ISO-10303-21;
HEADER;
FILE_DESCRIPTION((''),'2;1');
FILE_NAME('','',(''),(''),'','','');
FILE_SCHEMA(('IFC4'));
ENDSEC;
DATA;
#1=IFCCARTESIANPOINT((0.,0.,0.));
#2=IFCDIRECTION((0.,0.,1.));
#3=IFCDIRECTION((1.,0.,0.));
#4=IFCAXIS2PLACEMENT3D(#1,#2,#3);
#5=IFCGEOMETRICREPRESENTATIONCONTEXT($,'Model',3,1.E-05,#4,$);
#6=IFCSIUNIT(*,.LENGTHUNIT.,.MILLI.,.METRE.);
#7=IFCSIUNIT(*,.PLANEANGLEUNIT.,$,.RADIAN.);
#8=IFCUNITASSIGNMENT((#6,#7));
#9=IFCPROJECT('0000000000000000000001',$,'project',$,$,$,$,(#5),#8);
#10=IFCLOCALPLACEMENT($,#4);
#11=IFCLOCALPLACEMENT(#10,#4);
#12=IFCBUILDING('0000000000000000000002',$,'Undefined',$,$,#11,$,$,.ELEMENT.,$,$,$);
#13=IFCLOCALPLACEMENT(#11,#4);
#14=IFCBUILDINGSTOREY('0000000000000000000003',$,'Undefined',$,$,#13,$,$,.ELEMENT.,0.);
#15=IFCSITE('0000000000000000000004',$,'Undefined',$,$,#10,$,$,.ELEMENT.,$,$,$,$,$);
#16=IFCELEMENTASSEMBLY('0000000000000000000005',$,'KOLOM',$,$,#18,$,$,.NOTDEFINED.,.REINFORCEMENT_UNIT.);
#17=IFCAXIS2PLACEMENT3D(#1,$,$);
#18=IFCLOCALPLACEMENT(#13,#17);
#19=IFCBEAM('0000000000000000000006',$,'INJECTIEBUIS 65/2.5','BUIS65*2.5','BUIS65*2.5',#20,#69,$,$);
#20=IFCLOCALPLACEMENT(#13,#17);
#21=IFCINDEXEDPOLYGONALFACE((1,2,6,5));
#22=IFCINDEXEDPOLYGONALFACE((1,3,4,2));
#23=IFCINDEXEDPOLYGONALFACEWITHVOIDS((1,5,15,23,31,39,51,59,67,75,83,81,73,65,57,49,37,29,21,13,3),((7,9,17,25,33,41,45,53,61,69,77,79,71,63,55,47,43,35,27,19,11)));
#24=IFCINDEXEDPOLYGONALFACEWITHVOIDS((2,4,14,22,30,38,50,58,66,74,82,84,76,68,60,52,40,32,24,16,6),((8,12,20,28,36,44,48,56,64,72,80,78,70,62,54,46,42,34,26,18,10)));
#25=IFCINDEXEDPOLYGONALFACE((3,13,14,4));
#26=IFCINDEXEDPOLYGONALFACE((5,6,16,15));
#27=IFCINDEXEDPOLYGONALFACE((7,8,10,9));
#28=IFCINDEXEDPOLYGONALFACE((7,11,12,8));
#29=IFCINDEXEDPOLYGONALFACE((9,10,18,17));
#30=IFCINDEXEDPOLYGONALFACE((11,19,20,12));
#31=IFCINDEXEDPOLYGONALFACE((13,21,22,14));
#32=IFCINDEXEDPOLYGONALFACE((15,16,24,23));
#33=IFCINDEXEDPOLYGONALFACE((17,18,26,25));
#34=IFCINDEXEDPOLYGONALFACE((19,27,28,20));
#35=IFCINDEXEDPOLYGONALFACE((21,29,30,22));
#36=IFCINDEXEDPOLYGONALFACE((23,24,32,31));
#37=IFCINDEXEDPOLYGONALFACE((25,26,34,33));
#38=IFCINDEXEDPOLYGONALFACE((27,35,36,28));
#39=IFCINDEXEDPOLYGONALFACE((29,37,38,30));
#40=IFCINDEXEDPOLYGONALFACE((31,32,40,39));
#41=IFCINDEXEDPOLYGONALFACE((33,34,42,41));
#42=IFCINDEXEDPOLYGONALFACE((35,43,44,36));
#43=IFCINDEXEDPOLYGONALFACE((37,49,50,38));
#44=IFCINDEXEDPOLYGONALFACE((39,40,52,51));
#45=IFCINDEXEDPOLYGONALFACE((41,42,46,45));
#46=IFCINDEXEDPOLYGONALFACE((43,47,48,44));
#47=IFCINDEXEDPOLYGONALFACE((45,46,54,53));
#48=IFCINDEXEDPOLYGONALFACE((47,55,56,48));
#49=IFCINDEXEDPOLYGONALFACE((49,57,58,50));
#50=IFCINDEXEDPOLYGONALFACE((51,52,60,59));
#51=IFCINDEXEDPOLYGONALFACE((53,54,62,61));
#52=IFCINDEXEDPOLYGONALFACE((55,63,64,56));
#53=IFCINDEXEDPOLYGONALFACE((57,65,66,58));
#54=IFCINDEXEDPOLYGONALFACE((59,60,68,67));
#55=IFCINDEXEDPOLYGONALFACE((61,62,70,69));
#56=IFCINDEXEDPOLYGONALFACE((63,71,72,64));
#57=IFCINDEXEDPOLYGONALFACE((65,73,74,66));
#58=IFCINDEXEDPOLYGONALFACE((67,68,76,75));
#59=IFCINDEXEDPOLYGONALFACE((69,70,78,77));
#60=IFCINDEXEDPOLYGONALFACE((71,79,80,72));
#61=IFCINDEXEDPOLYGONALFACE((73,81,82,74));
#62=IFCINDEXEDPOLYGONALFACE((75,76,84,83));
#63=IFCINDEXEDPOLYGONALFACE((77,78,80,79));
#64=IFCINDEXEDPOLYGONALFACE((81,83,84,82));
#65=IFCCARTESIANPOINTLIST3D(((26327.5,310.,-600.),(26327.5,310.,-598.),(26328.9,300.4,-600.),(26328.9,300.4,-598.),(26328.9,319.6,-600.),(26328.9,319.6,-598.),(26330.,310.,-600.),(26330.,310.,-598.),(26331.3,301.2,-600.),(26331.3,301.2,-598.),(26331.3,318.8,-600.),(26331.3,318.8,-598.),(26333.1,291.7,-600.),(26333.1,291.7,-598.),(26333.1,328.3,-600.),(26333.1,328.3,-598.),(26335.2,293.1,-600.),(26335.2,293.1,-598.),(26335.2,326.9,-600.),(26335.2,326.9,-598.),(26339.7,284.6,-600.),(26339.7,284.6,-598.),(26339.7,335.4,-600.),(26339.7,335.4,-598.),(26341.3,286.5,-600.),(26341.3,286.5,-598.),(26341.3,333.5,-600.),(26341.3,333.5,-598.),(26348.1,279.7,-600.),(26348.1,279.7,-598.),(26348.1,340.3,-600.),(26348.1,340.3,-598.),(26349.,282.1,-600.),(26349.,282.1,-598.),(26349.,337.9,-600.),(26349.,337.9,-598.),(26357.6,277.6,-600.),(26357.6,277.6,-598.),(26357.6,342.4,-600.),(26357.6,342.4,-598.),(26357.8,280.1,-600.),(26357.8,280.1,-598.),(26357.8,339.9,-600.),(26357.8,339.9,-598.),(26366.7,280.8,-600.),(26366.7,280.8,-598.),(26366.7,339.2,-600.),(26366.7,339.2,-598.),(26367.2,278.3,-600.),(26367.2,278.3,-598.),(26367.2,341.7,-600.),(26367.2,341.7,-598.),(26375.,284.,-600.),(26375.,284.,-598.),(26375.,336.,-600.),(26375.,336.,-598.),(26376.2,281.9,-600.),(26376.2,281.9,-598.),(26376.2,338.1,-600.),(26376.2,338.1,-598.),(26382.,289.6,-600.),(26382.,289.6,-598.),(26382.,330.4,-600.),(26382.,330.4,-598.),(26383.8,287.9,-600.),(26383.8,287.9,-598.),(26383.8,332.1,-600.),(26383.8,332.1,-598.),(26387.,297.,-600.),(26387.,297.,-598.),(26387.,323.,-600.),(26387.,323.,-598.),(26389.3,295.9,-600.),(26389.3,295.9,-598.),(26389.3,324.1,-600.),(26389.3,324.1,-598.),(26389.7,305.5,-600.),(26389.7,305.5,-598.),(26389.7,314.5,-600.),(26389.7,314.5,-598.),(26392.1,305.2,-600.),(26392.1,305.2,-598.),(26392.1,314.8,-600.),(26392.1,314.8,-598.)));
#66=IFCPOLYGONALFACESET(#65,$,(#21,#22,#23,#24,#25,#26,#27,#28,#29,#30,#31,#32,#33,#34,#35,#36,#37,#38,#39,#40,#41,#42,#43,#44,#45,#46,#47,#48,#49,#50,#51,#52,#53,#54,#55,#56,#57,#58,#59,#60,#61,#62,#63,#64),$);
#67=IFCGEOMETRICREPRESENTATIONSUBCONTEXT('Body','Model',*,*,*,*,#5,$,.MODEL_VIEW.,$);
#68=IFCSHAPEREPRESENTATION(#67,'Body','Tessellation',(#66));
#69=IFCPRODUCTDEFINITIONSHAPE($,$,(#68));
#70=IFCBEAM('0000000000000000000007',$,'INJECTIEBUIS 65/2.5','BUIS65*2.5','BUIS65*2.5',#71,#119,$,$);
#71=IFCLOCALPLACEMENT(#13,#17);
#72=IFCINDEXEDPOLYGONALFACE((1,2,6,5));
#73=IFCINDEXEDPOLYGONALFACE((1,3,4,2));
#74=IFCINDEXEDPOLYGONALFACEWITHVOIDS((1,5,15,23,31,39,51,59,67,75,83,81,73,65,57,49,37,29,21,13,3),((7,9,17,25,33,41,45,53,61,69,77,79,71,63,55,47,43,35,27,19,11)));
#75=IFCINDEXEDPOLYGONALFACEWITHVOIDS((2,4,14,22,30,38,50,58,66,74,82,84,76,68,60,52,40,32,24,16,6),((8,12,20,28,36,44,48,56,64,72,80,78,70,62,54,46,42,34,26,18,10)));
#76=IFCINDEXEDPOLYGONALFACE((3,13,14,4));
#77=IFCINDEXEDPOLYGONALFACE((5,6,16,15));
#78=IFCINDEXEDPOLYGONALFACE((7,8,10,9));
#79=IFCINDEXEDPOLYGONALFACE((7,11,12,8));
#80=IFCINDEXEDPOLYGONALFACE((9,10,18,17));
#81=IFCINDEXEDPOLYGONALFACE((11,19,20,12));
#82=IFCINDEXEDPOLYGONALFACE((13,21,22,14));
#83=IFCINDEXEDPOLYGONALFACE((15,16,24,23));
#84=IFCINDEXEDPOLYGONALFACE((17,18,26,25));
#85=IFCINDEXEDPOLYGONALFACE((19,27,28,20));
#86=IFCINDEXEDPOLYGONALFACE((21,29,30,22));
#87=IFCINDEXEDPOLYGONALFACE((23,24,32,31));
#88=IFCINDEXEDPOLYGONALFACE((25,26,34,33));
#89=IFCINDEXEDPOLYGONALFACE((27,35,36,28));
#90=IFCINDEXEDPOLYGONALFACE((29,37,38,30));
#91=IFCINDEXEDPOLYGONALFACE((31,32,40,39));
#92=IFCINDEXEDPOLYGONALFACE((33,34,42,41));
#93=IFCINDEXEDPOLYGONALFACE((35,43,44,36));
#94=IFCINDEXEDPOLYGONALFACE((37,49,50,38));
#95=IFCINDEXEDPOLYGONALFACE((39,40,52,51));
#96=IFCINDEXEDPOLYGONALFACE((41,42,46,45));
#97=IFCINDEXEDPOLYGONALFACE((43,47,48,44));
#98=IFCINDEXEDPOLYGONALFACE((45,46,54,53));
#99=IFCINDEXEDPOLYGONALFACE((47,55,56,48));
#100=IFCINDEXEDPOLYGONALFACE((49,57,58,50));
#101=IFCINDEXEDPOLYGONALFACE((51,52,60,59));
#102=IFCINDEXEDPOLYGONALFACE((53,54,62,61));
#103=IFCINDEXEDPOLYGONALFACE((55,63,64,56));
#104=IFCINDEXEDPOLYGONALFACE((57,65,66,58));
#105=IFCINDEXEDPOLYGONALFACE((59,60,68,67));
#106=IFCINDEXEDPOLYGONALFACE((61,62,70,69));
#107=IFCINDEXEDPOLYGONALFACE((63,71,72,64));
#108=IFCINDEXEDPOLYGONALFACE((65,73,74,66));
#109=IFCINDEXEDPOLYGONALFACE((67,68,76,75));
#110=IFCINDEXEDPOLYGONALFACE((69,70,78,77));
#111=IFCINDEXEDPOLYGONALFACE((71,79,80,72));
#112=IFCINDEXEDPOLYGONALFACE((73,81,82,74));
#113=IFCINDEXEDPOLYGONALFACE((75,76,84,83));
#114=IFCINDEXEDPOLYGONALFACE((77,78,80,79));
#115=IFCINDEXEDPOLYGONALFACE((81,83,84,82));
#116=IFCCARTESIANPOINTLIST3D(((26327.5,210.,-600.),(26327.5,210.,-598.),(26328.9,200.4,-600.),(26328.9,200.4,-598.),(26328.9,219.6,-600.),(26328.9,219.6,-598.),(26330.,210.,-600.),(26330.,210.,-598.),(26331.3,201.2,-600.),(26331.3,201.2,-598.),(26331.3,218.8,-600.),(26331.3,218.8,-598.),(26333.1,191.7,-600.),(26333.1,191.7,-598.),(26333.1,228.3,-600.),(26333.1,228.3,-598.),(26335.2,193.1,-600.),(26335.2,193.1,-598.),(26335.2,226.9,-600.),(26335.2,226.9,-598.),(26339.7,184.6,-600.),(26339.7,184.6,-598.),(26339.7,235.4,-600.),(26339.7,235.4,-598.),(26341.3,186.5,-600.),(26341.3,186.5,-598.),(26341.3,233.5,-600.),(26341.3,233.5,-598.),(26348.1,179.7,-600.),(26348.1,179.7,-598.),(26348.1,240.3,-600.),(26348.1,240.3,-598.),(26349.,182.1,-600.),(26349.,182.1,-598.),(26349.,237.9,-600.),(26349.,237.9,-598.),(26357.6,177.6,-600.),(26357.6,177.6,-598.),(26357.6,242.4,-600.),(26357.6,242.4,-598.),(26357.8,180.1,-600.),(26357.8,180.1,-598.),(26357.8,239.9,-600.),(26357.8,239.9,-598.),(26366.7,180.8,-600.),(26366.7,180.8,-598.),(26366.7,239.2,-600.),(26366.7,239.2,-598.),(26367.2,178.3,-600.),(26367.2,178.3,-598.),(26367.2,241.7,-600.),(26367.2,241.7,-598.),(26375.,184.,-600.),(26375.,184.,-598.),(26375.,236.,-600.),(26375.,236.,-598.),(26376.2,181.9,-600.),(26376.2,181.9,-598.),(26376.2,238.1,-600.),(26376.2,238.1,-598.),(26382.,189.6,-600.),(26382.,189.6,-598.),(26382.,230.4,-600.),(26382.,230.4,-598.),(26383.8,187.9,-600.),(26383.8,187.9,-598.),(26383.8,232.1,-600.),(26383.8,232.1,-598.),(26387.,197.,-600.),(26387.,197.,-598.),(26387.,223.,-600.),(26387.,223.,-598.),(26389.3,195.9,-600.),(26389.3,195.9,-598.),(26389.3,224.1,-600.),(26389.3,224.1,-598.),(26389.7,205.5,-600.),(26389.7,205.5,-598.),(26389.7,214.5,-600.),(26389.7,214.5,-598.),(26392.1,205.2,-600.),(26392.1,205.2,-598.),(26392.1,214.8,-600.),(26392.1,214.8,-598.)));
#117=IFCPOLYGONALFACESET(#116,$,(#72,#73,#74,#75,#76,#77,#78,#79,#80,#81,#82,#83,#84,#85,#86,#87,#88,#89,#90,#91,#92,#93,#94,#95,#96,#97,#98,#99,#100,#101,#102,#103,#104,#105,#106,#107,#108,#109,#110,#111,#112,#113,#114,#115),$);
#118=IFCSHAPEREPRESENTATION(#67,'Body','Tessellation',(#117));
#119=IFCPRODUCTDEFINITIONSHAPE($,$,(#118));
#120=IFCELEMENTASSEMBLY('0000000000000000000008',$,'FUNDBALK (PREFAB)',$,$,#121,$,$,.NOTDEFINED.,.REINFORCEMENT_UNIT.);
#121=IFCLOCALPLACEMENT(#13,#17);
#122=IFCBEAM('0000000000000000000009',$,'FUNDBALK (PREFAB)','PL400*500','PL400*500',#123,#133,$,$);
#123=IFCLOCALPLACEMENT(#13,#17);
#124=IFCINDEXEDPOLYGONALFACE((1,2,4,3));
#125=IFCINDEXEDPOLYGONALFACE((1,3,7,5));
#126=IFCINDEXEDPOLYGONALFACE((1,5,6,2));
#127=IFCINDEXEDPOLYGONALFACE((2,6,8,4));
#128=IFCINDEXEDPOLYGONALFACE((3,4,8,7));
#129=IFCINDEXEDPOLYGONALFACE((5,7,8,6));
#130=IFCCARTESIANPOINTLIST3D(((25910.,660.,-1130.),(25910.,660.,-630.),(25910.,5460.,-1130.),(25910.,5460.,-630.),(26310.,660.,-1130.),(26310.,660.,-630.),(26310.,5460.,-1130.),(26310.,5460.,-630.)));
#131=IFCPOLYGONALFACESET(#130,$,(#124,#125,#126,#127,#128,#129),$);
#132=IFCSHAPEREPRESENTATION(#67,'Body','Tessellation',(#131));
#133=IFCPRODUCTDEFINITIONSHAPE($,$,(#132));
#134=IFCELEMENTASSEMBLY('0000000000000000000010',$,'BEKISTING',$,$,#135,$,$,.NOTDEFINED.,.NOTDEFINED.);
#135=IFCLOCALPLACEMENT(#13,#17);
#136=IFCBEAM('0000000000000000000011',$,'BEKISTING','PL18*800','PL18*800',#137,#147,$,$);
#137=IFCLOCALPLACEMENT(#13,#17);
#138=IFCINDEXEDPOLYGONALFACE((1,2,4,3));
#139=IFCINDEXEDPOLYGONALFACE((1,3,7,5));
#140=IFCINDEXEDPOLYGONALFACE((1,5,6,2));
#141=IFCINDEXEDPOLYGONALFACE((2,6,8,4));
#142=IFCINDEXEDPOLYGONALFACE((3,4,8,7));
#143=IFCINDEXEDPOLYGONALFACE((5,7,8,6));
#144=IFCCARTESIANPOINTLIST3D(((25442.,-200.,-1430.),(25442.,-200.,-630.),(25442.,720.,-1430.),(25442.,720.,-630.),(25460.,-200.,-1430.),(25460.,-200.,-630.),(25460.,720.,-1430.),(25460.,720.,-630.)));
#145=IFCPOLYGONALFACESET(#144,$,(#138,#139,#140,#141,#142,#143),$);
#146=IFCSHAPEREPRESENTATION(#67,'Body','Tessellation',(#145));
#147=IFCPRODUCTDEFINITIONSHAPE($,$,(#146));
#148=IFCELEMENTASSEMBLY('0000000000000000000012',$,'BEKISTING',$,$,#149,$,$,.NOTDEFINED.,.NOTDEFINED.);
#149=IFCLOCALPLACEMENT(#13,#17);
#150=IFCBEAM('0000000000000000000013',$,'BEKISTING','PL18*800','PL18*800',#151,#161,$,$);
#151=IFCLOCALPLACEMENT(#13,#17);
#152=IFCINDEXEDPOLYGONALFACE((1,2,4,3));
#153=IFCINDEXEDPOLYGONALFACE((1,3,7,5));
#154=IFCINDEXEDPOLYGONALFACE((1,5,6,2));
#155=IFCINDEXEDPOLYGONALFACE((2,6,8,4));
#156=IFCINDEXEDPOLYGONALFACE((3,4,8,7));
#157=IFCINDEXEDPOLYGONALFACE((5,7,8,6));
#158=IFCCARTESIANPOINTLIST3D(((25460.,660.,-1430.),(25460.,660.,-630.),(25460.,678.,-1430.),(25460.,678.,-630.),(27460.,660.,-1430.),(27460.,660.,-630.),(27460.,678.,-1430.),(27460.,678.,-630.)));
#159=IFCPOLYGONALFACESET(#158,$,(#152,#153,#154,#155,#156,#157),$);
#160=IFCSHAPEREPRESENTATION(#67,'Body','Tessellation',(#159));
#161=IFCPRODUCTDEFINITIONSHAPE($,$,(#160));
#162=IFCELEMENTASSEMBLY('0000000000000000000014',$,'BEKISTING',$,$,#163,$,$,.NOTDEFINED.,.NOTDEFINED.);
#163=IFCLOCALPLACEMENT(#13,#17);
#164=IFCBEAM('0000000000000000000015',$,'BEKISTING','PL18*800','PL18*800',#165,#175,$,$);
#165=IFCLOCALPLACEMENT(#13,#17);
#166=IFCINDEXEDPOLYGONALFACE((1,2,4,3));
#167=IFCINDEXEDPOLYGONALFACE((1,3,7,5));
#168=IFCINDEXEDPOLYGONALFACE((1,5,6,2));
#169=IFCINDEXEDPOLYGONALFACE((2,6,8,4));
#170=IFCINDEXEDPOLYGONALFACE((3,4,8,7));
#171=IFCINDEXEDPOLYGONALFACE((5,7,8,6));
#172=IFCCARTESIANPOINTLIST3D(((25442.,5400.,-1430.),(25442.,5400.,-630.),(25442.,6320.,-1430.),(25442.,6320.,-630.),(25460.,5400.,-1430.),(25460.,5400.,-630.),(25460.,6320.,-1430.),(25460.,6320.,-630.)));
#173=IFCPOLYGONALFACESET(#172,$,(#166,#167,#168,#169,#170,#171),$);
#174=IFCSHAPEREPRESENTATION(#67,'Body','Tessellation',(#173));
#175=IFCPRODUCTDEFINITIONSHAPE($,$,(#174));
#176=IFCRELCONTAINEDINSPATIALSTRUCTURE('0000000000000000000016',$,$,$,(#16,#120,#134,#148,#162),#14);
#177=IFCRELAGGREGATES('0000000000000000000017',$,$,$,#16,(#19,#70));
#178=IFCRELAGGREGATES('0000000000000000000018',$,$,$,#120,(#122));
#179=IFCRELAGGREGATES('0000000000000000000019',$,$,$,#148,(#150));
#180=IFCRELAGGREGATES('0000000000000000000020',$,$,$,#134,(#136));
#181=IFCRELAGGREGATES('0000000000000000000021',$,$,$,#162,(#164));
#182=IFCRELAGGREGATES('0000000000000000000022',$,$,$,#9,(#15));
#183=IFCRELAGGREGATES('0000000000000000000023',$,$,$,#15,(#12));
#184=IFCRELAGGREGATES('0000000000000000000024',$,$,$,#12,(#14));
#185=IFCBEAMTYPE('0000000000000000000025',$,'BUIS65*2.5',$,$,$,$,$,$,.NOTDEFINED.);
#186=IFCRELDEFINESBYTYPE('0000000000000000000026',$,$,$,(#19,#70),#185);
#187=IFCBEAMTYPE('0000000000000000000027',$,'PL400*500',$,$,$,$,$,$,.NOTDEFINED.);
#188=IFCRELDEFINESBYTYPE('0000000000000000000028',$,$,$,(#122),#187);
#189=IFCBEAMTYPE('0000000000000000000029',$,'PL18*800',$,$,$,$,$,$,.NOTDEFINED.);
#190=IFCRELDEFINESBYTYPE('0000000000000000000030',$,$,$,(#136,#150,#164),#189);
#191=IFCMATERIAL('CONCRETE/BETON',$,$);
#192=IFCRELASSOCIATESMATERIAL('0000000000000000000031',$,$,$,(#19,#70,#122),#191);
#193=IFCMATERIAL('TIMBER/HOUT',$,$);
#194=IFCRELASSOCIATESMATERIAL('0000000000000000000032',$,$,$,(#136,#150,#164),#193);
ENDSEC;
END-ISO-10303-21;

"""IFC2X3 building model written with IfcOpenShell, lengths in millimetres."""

from ifc_helpers import new_model, si_unit, frame, frame_2d, origin_with_axes, place, context, subcontext, project, spatial, rectangle, hollow_circle, extrude, material, type_object, element, aggregate, save


model = new_model("IFC2X3")

# Units and contexts
model_context = context("Model", 3, precision=1e-05, world=origin_with_axes())
body_context = subcontext(model_context, "Body", "Model", "MODEL_VIEW")
ifc_project = project(units=[si_unit("LENGTHUNIT", "METRE", prefix="MILLI"), si_unit("PLANEANGLEUNIT", "RADIAN")], contexts=[model_context])

# Site, building, storey
site_placement = place(None, origin_with_axes())
site = spatial("IfcSite", under=ifc_project, at=site_placement, Name="Undefined", CompositionType="ELEMENT")
building_placement = place(site_placement, origin_with_axes())
building = spatial("IfcBuilding", under=site, at=building_placement, Name="Undefined", CompositionType="ELEMENT")
storey_placement = place(building_placement, origin_with_axes())
storey = spatial("IfcBuildingStorey", under=building, at=storey_placement, Name="Undefined", CompositionType="ELEMENT", Elevation=0.0)

# Shared definitions
ifc_material_1 = material(Name="CONCRETE/BETON")

# Element assembly, beams
assembly_1_placement = place(storey_placement, origin_with_axes())
assembly_1 = element("IfcElementAssembly", 1, at=assembly_1_placement, inside=storey, Name="KOLOM", AssemblyPlace="NOTDEFINED", PredefinedType="REINFORCEMENT_UNIT")
beam_type_1 = type_object("IfcBeamType", Name="BUIS65*2.5", PredefinedType="NOTDEFINED")
beam_1_placement = place(assembly_1_placement, frame((26360.0, 310.0, -600.0), z_axis=(0.0, 1.0, 0.0), x_axis=(0.0, 0.0, 1.0)))
beam_1 = element("IfcBeam", 2, at=beam_1_placement, type_object=beam_type_1, material=ifc_material_1, Name="INJECTIEBUIS 65/2.5", Description="BUIS65*2.5", ObjectType="BUIS65*2.5", context=body_context, shape_type="SweptSolid", body=[
    extrude(hollow_circle(Radius=32.5, WallThickness=2.5, at=frame_2d((0.0, 0.0), x_axis=(1.0, 0.0))), frame((2.0, 0.0, 0.0), z_axis=(-1.0, 0.0, 0.0), x_axis=(0.0, -1.0, 0.0)), (0.0, 0.0, 1.0), 2.0),
])
beam_2_placement = place(assembly_1_placement, frame((26360.0, 210.0, -600.0), z_axis=(0.0, 1.0, 0.0), x_axis=(0.0, 0.0, 1.0)))
beam_2 = element("IfcBeam", 3, at=beam_2_placement, type_object=beam_type_1, material=ifc_material_1, Name="INJECTIEBUIS 65/2.5", Description="BUIS65*2.5", ObjectType="BUIS65*2.5", context=body_context, shape_type="SweptSolid", body=[
    extrude(hollow_circle(Radius=32.5, WallThickness=2.5, at=frame_2d((0.0, 0.0), x_axis=(1.0, 0.0))), frame((2.0, 0.0, 0.0), z_axis=(-1.0, 0.0, 0.0), x_axis=(0.0, -1.0, 0.0)), (0.0, 0.0, 1.0), 2.0),
])
aggregate(assembly_1, [beam_1, beam_2])

# Element assemblies, beams
assembly_2_placement = place(storey_placement, origin_with_axes())
assembly_2 = element("IfcElementAssembly", 4, at=assembly_2_placement, inside=storey, Name="FUNDBALK (PREFAB)", AssemblyPlace="NOTDEFINED", PredefinedType="REINFORCEMENT_UNIT")
beam_type_2 = type_object("IfcBeamType", Name="PL400*500", PredefinedType="NOTDEFINED")
beam_3_placement = place(assembly_2_placement, frame((26110.0, 5460.0, -880.0), z_axis=(0.0, 0.0, 1.0), x_axis=(0.0, -1.0, 0.0)))
beam_3 = element("IfcBeam", 5, at=beam_3_placement, type_object=beam_type_2, material=ifc_material_1, Name="FUNDBALK (PREFAB)", Description="PL400*500", ObjectType="PL400*500", context=body_context, shape_type="SweptSolid", body=[
    extrude(rectangle(XDim=400.0, YDim=500.0, at=frame_2d((0.0, 0.0), x_axis=(1.0, 0.0))), frame((4800.0, 0.0, 0.0), z_axis=(-1.0, 0.0, 0.0), x_axis=(0.0, -1.0, 0.0)), (0.0, 0.0, 1.0), 4800.0),
])
aggregate(assembly_2, [beam_3])
assembly_3_placement = place(storey_placement, origin_with_axes())
assembly_3 = element("IfcElementAssembly", 6, at=assembly_3_placement, inside=storey, Name="BEKISTING", AssemblyPlace="NOTDEFINED", PredefinedType="NOTDEFINED")
ifc_material_2 = material(Name="TIMBER/HOUT")
beam_type_3 = type_object("IfcBeamType", Name="PL18*800", PredefinedType="NOTDEFINED")
beam_4_placement = place(assembly_3_placement, frame((25451.0, -200.0, -1030.0), z_axis=(0.0, 0.0, -1.0), x_axis=(0.0, 1.0, 0.0)))
beam_4 = element("IfcBeam", 7, at=beam_4_placement, type_object=beam_type_3, material=ifc_material_2, Name="BEKISTING", Description="PL18*800", ObjectType="PL18*800", context=body_context, shape_type="SweptSolid", body=[
    extrude(rectangle(XDim=18.0, YDim=800.0, at=frame_2d((0.0, 0.0), x_axis=(1.0, 0.0))), frame((920.0, 0.0, 0.0), z_axis=(-1.0, 0.0, 0.0), x_axis=(0.0, -1.0, 0.0)), (0.0, 0.0, 1.0), 920.0),
])
assembly_4_placement = place(storey_placement, origin_with_axes())
assembly_4 = element("IfcElementAssembly", 8, at=assembly_4_placement, inside=storey, Name="BEKISTING", AssemblyPlace="NOTDEFINED", PredefinedType="NOTDEFINED")
beam_5_placement = place(assembly_4_placement, frame((25460.0, 669.0, -1030.0), z_axis=(0.0, 0.0, 1.0), x_axis=(1.0, 0.0, 0.0)))
beam_5 = element("IfcBeam", 9, at=beam_5_placement, type_object=beam_type_3, material=ifc_material_2, Name="BEKISTING", Description="PL18*800", ObjectType="PL18*800", context=body_context, shape_type="SweptSolid", body=[
    extrude(rectangle(XDim=18.0, YDim=800.0, at=frame_2d((0.0, 0.0), x_axis=(1.0, 0.0))), frame((2000.0, 0.0, 0.0), z_axis=(-1.0, 0.0, 0.0), x_axis=(0.0, -1.0, 0.0)), (0.0, 0.0, 1.0), 2000.0),
])
aggregate(assembly_4, [beam_5])
assembly_5_placement = place(storey_placement, origin_with_axes())
assembly_5 = element("IfcElementAssembly", 10, at=assembly_5_placement, inside=storey, Name="BEKISTING", AssemblyPlace="NOTDEFINED", PredefinedType="NOTDEFINED")
beam_6_placement = place(assembly_5_placement, frame((25451.0, 5400.0, -1030.0), z_axis=(0.0, 0.0, -1.0), x_axis=(0.0, 1.0, 0.0)))
beam_6 = element("IfcBeam", 11, at=beam_6_placement, type_object=beam_type_3, material=ifc_material_2, Name="BEKISTING", Description="PL18*800", ObjectType="PL18*800", context=body_context, shape_type="SweptSolid", body=[
    extrude(rectangle(XDim=18.0, YDim=800.0, at=frame_2d((0.0, 0.0), x_axis=(1.0, 0.0))), frame((920.0, 0.0, 0.0), z_axis=(-1.0, 0.0, 0.0), x_axis=(0.0, -1.0, 0.0)), (0.0, 0.0, 1.0), 920.0),
])

aggregate(assembly_3, [beam_4])
aggregate(assembly_5, [beam_6])

save(model, "model.ifc")
